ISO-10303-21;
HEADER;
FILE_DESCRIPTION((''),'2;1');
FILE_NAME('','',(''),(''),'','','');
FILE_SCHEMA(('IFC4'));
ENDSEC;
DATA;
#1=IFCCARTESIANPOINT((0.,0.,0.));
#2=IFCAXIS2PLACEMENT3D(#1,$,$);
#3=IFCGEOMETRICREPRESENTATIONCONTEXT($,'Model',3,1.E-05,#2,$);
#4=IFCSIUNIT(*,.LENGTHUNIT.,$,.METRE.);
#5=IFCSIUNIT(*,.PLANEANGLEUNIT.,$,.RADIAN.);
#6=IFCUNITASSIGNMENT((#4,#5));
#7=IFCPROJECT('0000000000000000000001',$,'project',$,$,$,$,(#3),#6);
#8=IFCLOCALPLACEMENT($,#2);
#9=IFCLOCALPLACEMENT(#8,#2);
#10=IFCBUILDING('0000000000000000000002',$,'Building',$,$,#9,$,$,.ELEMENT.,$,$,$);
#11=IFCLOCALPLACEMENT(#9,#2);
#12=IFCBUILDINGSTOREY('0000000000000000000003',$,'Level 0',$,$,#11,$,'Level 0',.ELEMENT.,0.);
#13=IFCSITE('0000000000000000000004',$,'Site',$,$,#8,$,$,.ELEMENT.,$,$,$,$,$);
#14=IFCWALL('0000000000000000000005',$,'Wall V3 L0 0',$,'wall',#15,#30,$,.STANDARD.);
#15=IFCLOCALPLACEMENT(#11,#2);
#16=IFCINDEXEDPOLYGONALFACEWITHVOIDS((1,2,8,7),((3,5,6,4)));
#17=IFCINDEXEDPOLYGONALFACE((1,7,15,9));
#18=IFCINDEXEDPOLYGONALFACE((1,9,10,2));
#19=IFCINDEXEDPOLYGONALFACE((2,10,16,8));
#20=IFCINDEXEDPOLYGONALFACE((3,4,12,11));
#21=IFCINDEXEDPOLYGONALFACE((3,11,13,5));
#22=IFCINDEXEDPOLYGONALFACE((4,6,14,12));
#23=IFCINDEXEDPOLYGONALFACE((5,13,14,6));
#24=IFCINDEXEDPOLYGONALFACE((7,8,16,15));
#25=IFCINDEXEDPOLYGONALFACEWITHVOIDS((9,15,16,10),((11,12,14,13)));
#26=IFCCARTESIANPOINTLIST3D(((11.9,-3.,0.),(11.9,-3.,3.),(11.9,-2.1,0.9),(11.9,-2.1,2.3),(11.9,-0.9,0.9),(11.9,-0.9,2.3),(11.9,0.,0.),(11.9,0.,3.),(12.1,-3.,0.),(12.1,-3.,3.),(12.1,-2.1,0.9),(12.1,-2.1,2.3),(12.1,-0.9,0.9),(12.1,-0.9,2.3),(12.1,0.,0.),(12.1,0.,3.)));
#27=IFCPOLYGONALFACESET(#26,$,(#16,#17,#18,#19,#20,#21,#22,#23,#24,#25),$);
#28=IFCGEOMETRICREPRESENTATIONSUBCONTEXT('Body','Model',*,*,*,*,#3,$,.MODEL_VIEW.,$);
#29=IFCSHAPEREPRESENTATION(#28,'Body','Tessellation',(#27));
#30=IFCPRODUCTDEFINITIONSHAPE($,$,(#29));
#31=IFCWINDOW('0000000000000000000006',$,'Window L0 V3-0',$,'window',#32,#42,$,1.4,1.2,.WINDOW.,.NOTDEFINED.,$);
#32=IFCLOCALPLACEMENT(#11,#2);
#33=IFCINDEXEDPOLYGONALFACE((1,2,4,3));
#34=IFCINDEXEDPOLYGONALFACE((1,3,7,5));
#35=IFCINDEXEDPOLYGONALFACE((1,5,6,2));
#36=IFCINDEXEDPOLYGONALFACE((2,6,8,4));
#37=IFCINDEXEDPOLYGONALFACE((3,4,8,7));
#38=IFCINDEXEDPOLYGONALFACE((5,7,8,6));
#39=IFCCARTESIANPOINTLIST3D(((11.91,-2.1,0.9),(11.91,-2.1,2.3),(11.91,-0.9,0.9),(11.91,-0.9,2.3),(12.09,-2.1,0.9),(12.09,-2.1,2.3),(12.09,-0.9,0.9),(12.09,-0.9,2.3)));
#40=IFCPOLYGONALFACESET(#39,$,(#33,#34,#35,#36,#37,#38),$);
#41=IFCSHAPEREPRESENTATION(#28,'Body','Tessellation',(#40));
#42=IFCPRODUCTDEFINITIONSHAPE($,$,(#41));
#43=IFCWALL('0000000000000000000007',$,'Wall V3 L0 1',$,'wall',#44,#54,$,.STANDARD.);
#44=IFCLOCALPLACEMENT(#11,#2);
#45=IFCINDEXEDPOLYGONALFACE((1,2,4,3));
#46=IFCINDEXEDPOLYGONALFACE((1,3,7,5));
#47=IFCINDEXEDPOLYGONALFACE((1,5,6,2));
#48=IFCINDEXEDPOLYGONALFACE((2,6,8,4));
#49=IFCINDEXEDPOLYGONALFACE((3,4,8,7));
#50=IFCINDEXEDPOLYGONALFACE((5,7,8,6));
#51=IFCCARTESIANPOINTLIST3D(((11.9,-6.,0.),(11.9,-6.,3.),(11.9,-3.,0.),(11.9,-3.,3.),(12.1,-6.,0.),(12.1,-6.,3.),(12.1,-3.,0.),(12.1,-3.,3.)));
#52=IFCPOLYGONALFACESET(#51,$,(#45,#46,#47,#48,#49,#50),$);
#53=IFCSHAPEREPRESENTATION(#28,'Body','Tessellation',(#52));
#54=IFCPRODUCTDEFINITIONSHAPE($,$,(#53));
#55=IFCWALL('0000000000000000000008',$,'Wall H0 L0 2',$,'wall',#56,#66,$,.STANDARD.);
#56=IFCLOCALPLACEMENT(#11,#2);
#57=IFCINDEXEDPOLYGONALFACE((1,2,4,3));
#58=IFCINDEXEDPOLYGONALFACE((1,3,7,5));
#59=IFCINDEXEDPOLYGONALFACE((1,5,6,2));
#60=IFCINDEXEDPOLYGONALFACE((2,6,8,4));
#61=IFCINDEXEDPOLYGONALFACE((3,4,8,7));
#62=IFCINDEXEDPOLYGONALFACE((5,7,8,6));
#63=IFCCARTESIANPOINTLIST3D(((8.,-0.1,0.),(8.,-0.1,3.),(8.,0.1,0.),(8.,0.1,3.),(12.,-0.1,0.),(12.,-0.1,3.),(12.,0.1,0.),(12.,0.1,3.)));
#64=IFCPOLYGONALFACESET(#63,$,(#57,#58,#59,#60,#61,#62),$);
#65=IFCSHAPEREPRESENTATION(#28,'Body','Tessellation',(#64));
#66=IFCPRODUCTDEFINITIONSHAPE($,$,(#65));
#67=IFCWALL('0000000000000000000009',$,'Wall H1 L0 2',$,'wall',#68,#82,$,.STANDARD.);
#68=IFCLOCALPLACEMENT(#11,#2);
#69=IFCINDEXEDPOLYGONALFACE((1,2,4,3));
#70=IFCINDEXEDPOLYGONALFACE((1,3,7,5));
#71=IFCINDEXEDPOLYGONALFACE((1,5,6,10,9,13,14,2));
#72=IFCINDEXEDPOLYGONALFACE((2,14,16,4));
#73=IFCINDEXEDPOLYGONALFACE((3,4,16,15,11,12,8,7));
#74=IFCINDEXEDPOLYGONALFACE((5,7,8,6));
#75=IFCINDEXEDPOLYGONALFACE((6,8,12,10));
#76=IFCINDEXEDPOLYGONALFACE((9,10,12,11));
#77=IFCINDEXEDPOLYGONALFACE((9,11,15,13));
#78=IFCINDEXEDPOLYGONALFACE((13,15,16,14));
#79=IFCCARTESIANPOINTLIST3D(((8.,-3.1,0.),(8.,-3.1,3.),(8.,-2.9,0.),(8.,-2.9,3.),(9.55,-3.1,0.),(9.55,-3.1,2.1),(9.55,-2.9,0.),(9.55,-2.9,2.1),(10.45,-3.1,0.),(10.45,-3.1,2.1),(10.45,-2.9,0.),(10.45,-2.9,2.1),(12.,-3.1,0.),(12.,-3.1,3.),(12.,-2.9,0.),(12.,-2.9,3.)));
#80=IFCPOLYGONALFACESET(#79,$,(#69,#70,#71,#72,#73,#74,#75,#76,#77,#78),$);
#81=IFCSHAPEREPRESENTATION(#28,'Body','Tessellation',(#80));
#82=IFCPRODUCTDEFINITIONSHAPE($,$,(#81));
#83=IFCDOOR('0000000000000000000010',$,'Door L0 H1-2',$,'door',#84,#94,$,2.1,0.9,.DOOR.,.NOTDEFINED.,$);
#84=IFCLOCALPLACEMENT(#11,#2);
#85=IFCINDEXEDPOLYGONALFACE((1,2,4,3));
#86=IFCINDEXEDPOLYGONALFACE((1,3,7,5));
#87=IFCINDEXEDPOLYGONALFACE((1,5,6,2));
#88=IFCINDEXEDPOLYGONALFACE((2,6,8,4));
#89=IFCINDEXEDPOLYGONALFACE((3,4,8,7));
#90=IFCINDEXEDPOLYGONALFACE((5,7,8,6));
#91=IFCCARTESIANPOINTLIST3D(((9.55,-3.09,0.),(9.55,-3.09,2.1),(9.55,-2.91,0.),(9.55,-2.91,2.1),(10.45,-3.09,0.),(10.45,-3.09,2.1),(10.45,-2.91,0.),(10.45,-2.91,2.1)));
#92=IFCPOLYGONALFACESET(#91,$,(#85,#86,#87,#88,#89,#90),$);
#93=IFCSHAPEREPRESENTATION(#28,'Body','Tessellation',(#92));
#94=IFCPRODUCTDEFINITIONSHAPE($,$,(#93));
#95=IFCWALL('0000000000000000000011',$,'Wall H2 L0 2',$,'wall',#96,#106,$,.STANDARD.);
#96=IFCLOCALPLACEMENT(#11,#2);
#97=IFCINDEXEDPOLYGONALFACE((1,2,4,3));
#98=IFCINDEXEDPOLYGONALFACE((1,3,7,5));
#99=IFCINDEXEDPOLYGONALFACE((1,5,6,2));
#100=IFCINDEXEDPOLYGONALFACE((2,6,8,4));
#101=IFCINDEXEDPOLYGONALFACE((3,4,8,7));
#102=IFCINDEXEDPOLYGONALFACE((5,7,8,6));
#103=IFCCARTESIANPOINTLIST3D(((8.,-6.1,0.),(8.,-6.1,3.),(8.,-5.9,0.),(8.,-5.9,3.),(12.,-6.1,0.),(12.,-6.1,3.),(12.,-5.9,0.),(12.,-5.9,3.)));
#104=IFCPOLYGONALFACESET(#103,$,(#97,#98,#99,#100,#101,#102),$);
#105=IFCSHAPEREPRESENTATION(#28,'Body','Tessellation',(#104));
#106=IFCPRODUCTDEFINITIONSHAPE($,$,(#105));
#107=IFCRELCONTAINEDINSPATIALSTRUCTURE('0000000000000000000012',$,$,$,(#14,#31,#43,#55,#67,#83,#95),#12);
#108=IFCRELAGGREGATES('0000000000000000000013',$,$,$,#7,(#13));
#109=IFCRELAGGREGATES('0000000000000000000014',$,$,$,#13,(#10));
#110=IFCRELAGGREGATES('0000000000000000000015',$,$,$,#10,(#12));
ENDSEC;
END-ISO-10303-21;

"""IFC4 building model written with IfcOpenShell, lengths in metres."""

from ifc_helpers import new_model, si_unit, frame, frame_2d, origin, origin_2d, place, context, subcontext, project, spatial, rectangle, extrude, element, fill, save


model = new_model("IFC4")

# Units and contexts
model_context = context("Model", 3, precision=1e-05, world=origin())
body_context = subcontext(model_context, "Body", "Model", "MODEL_VIEW")
ifc_project = project(units=[si_unit("LENGTHUNIT", "METRE"), si_unit("PLANEANGLEUNIT", "RADIAN")], contexts=[model_context])

# Site, building, storey
site_placement = place(None, origin())
site = spatial("IfcSite", under=ifc_project, at=site_placement, Name="Site", CompositionType="ELEMENT")
building_placement = place(site_placement, origin())
building = spatial("IfcBuilding", under=site, at=building_placement, Name="Building", CompositionType="ELEMENT")
storey_placement = place(building_placement, origin())
storey = spatial("IfcBuildingStorey", under=building, at=storey_placement, Name="Level 0", LongName="Level 0", CompositionType="ELEMENT", Elevation=0.0)

# Wall, opening, window
wall_1_placement = place(storey_placement, frame((12.0, 0.0, 0.0), z_axis=(0.0, 0.0, 1.0), x_axis=(0.0, -1.0, 0.0)))
wall_1 = element("IfcWall", 1, at=wall_1_placement, inside=storey, Name="Wall V3 L0 0", ObjectType="wall", PredefinedType="STANDARD", context=body_context, shape_type="SweptSolid", body=[
    extrude(rectangle(XDim=3.0, YDim=0.2, at=frame_2d((1.5, 0.0))), origin(), (0.0, 0.0, 1.0), 3.0),
])
opening_1_placement = place(storey_placement, frame((12.0, -1.5, 0.9), z_axis=(0.0, 0.0, 1.0), x_axis=(0.0, -1.0, 0.0)))
opening_1 = element("IfcOpeningElement", 2, at=opening_1_placement, cuts=wall_1, ObjectType="Opening", PredefinedType="OPENING", context=body_context, shape_type="SweptSolid", body=[
    extrude(rectangle(XDim=1.2, YDim=0.22, at=origin_2d()), origin(), (0.0, 0.0, 1.0), 1.4),
])
window_placement = place(storey_placement, frame((12.0, -1.5, 0.9), z_axis=(0.0, 0.0, 1.0), x_axis=(0.0, -1.0, 0.0)))
window = element("IfcWindow", 3, at=window_placement, inside=storey, Name="Window L0 V3-0", ObjectType="window", OverallHeight=1.4, OverallWidth=1.2, PartitioningType="NOTDEFINED", PredefinedType="WINDOW", context=body_context, shape_type="SweptSolid", body=[
    extrude(rectangle(XDim=1.2, YDim=0.18, at=origin_2d()), origin(), (0.0, 0.0, 1.0), 1.4),
])
fill(opening_1, window)

# Walls
wall_2_placement = place(storey_placement, frame((12.0, -3.0, 0.0), z_axis=(0.0, 0.0, 1.0), x_axis=(0.0, -1.0, 0.0)))
element("IfcWall", 4, at=wall_2_placement, inside=storey, Name="Wall V3 L0 1", ObjectType="wall", PredefinedType="STANDARD", context=body_context, shape_type="SweptSolid", body=[
    extrude(rectangle(XDim=3.0, YDim=0.2, at=frame_2d((1.5, 0.0))), origin(), (0.0, 0.0, 1.0), 3.0),
])
wall_3_placement = place(storey_placement, frame((8.0, 0.0, 0.0), z_axis=(0.0, 0.0, 1.0), x_axis=(1.0, 0.0, 0.0)))
element("IfcWall", 5, at=wall_3_placement, inside=storey, Name="Wall H0 L0 2", ObjectType="wall", PredefinedType="STANDARD", context=body_context, shape_type="SweptSolid", body=[
    extrude(rectangle(XDim=4.0, YDim=0.2, at=frame_2d((2.0, 0.0))), origin(), (0.0, 0.0, 1.0), 3.0),
])

# Wall, opening, door
wall_4_placement = place(storey_placement, frame((8.0, -3.0, 0.0), z_axis=(0.0, 0.0, 1.0), x_axis=(1.0, 0.0, 0.0)))
wall_4 = element("IfcWall", 6, at=wall_4_placement, inside=storey, Name="Wall H1 L0 2", ObjectType="wall", PredefinedType="STANDARD", context=body_context, shape_type="SweptSolid", body=[
    extrude(rectangle(XDim=4.0, YDim=0.2, at=frame_2d((2.0, 0.0))), origin(), (0.0, 0.0, 1.0), 3.0),
])
opening_2_placement = place(storey_placement, frame((10.0, -3.0, 0.0), z_axis=(0.0, 0.0, 1.0), x_axis=(1.0, 0.0, 0.0)))
opening_2 = element("IfcOpeningElement", 7, at=opening_2_placement, cuts=wall_4, ObjectType="Opening", PredefinedType="OPENING", context=body_context, shape_type="SweptSolid", body=[
    extrude(rectangle(XDim=0.9, YDim=0.22, at=origin_2d()), origin(), (0.0, 0.0, 1.0), 2.1),
])
door_1_placement = place(storey_placement, frame((10.0, -3.0, 0.0), z_axis=(0.0, 0.0, 1.0), x_axis=(1.0, 0.0, 0.0)))
door_1 = element("IfcDoor", 8, at=door_1_placement, inside=storey, Name="Door L0 H1-2", ObjectType="door", OperationType="NOTDEFINED", OverallHeight=2.1, OverallWidth=0.9, PredefinedType="DOOR", context=body_context, shape_type="SweptSolid", body=[
    extrude(rectangle(XDim=0.9, YDim=0.18, at=origin_2d()), origin(), (0.0, 0.0, 1.0), 2.1),
])
fill(opening_2, door_1)

# Wall
wall_5_placement = place(storey_placement, frame((8.0, -6.0, 0.0), z_axis=(0.0, 0.0, 1.0), x_axis=(1.0, 0.0, 0.0)))
element("IfcWall", 9, at=wall_5_placement, inside=storey, Name="Wall H2 L0 2", ObjectType="wall", PredefinedType="STANDARD", context=body_context, shape_type="SweptSolid", body=[
    extrude(rectangle(XDim=4.0, YDim=0.2, at=frame_2d((2.0, 0.0))), origin(), (0.0, 0.0, 1.0), 3.0),
])

save(model, "model.ifc")
